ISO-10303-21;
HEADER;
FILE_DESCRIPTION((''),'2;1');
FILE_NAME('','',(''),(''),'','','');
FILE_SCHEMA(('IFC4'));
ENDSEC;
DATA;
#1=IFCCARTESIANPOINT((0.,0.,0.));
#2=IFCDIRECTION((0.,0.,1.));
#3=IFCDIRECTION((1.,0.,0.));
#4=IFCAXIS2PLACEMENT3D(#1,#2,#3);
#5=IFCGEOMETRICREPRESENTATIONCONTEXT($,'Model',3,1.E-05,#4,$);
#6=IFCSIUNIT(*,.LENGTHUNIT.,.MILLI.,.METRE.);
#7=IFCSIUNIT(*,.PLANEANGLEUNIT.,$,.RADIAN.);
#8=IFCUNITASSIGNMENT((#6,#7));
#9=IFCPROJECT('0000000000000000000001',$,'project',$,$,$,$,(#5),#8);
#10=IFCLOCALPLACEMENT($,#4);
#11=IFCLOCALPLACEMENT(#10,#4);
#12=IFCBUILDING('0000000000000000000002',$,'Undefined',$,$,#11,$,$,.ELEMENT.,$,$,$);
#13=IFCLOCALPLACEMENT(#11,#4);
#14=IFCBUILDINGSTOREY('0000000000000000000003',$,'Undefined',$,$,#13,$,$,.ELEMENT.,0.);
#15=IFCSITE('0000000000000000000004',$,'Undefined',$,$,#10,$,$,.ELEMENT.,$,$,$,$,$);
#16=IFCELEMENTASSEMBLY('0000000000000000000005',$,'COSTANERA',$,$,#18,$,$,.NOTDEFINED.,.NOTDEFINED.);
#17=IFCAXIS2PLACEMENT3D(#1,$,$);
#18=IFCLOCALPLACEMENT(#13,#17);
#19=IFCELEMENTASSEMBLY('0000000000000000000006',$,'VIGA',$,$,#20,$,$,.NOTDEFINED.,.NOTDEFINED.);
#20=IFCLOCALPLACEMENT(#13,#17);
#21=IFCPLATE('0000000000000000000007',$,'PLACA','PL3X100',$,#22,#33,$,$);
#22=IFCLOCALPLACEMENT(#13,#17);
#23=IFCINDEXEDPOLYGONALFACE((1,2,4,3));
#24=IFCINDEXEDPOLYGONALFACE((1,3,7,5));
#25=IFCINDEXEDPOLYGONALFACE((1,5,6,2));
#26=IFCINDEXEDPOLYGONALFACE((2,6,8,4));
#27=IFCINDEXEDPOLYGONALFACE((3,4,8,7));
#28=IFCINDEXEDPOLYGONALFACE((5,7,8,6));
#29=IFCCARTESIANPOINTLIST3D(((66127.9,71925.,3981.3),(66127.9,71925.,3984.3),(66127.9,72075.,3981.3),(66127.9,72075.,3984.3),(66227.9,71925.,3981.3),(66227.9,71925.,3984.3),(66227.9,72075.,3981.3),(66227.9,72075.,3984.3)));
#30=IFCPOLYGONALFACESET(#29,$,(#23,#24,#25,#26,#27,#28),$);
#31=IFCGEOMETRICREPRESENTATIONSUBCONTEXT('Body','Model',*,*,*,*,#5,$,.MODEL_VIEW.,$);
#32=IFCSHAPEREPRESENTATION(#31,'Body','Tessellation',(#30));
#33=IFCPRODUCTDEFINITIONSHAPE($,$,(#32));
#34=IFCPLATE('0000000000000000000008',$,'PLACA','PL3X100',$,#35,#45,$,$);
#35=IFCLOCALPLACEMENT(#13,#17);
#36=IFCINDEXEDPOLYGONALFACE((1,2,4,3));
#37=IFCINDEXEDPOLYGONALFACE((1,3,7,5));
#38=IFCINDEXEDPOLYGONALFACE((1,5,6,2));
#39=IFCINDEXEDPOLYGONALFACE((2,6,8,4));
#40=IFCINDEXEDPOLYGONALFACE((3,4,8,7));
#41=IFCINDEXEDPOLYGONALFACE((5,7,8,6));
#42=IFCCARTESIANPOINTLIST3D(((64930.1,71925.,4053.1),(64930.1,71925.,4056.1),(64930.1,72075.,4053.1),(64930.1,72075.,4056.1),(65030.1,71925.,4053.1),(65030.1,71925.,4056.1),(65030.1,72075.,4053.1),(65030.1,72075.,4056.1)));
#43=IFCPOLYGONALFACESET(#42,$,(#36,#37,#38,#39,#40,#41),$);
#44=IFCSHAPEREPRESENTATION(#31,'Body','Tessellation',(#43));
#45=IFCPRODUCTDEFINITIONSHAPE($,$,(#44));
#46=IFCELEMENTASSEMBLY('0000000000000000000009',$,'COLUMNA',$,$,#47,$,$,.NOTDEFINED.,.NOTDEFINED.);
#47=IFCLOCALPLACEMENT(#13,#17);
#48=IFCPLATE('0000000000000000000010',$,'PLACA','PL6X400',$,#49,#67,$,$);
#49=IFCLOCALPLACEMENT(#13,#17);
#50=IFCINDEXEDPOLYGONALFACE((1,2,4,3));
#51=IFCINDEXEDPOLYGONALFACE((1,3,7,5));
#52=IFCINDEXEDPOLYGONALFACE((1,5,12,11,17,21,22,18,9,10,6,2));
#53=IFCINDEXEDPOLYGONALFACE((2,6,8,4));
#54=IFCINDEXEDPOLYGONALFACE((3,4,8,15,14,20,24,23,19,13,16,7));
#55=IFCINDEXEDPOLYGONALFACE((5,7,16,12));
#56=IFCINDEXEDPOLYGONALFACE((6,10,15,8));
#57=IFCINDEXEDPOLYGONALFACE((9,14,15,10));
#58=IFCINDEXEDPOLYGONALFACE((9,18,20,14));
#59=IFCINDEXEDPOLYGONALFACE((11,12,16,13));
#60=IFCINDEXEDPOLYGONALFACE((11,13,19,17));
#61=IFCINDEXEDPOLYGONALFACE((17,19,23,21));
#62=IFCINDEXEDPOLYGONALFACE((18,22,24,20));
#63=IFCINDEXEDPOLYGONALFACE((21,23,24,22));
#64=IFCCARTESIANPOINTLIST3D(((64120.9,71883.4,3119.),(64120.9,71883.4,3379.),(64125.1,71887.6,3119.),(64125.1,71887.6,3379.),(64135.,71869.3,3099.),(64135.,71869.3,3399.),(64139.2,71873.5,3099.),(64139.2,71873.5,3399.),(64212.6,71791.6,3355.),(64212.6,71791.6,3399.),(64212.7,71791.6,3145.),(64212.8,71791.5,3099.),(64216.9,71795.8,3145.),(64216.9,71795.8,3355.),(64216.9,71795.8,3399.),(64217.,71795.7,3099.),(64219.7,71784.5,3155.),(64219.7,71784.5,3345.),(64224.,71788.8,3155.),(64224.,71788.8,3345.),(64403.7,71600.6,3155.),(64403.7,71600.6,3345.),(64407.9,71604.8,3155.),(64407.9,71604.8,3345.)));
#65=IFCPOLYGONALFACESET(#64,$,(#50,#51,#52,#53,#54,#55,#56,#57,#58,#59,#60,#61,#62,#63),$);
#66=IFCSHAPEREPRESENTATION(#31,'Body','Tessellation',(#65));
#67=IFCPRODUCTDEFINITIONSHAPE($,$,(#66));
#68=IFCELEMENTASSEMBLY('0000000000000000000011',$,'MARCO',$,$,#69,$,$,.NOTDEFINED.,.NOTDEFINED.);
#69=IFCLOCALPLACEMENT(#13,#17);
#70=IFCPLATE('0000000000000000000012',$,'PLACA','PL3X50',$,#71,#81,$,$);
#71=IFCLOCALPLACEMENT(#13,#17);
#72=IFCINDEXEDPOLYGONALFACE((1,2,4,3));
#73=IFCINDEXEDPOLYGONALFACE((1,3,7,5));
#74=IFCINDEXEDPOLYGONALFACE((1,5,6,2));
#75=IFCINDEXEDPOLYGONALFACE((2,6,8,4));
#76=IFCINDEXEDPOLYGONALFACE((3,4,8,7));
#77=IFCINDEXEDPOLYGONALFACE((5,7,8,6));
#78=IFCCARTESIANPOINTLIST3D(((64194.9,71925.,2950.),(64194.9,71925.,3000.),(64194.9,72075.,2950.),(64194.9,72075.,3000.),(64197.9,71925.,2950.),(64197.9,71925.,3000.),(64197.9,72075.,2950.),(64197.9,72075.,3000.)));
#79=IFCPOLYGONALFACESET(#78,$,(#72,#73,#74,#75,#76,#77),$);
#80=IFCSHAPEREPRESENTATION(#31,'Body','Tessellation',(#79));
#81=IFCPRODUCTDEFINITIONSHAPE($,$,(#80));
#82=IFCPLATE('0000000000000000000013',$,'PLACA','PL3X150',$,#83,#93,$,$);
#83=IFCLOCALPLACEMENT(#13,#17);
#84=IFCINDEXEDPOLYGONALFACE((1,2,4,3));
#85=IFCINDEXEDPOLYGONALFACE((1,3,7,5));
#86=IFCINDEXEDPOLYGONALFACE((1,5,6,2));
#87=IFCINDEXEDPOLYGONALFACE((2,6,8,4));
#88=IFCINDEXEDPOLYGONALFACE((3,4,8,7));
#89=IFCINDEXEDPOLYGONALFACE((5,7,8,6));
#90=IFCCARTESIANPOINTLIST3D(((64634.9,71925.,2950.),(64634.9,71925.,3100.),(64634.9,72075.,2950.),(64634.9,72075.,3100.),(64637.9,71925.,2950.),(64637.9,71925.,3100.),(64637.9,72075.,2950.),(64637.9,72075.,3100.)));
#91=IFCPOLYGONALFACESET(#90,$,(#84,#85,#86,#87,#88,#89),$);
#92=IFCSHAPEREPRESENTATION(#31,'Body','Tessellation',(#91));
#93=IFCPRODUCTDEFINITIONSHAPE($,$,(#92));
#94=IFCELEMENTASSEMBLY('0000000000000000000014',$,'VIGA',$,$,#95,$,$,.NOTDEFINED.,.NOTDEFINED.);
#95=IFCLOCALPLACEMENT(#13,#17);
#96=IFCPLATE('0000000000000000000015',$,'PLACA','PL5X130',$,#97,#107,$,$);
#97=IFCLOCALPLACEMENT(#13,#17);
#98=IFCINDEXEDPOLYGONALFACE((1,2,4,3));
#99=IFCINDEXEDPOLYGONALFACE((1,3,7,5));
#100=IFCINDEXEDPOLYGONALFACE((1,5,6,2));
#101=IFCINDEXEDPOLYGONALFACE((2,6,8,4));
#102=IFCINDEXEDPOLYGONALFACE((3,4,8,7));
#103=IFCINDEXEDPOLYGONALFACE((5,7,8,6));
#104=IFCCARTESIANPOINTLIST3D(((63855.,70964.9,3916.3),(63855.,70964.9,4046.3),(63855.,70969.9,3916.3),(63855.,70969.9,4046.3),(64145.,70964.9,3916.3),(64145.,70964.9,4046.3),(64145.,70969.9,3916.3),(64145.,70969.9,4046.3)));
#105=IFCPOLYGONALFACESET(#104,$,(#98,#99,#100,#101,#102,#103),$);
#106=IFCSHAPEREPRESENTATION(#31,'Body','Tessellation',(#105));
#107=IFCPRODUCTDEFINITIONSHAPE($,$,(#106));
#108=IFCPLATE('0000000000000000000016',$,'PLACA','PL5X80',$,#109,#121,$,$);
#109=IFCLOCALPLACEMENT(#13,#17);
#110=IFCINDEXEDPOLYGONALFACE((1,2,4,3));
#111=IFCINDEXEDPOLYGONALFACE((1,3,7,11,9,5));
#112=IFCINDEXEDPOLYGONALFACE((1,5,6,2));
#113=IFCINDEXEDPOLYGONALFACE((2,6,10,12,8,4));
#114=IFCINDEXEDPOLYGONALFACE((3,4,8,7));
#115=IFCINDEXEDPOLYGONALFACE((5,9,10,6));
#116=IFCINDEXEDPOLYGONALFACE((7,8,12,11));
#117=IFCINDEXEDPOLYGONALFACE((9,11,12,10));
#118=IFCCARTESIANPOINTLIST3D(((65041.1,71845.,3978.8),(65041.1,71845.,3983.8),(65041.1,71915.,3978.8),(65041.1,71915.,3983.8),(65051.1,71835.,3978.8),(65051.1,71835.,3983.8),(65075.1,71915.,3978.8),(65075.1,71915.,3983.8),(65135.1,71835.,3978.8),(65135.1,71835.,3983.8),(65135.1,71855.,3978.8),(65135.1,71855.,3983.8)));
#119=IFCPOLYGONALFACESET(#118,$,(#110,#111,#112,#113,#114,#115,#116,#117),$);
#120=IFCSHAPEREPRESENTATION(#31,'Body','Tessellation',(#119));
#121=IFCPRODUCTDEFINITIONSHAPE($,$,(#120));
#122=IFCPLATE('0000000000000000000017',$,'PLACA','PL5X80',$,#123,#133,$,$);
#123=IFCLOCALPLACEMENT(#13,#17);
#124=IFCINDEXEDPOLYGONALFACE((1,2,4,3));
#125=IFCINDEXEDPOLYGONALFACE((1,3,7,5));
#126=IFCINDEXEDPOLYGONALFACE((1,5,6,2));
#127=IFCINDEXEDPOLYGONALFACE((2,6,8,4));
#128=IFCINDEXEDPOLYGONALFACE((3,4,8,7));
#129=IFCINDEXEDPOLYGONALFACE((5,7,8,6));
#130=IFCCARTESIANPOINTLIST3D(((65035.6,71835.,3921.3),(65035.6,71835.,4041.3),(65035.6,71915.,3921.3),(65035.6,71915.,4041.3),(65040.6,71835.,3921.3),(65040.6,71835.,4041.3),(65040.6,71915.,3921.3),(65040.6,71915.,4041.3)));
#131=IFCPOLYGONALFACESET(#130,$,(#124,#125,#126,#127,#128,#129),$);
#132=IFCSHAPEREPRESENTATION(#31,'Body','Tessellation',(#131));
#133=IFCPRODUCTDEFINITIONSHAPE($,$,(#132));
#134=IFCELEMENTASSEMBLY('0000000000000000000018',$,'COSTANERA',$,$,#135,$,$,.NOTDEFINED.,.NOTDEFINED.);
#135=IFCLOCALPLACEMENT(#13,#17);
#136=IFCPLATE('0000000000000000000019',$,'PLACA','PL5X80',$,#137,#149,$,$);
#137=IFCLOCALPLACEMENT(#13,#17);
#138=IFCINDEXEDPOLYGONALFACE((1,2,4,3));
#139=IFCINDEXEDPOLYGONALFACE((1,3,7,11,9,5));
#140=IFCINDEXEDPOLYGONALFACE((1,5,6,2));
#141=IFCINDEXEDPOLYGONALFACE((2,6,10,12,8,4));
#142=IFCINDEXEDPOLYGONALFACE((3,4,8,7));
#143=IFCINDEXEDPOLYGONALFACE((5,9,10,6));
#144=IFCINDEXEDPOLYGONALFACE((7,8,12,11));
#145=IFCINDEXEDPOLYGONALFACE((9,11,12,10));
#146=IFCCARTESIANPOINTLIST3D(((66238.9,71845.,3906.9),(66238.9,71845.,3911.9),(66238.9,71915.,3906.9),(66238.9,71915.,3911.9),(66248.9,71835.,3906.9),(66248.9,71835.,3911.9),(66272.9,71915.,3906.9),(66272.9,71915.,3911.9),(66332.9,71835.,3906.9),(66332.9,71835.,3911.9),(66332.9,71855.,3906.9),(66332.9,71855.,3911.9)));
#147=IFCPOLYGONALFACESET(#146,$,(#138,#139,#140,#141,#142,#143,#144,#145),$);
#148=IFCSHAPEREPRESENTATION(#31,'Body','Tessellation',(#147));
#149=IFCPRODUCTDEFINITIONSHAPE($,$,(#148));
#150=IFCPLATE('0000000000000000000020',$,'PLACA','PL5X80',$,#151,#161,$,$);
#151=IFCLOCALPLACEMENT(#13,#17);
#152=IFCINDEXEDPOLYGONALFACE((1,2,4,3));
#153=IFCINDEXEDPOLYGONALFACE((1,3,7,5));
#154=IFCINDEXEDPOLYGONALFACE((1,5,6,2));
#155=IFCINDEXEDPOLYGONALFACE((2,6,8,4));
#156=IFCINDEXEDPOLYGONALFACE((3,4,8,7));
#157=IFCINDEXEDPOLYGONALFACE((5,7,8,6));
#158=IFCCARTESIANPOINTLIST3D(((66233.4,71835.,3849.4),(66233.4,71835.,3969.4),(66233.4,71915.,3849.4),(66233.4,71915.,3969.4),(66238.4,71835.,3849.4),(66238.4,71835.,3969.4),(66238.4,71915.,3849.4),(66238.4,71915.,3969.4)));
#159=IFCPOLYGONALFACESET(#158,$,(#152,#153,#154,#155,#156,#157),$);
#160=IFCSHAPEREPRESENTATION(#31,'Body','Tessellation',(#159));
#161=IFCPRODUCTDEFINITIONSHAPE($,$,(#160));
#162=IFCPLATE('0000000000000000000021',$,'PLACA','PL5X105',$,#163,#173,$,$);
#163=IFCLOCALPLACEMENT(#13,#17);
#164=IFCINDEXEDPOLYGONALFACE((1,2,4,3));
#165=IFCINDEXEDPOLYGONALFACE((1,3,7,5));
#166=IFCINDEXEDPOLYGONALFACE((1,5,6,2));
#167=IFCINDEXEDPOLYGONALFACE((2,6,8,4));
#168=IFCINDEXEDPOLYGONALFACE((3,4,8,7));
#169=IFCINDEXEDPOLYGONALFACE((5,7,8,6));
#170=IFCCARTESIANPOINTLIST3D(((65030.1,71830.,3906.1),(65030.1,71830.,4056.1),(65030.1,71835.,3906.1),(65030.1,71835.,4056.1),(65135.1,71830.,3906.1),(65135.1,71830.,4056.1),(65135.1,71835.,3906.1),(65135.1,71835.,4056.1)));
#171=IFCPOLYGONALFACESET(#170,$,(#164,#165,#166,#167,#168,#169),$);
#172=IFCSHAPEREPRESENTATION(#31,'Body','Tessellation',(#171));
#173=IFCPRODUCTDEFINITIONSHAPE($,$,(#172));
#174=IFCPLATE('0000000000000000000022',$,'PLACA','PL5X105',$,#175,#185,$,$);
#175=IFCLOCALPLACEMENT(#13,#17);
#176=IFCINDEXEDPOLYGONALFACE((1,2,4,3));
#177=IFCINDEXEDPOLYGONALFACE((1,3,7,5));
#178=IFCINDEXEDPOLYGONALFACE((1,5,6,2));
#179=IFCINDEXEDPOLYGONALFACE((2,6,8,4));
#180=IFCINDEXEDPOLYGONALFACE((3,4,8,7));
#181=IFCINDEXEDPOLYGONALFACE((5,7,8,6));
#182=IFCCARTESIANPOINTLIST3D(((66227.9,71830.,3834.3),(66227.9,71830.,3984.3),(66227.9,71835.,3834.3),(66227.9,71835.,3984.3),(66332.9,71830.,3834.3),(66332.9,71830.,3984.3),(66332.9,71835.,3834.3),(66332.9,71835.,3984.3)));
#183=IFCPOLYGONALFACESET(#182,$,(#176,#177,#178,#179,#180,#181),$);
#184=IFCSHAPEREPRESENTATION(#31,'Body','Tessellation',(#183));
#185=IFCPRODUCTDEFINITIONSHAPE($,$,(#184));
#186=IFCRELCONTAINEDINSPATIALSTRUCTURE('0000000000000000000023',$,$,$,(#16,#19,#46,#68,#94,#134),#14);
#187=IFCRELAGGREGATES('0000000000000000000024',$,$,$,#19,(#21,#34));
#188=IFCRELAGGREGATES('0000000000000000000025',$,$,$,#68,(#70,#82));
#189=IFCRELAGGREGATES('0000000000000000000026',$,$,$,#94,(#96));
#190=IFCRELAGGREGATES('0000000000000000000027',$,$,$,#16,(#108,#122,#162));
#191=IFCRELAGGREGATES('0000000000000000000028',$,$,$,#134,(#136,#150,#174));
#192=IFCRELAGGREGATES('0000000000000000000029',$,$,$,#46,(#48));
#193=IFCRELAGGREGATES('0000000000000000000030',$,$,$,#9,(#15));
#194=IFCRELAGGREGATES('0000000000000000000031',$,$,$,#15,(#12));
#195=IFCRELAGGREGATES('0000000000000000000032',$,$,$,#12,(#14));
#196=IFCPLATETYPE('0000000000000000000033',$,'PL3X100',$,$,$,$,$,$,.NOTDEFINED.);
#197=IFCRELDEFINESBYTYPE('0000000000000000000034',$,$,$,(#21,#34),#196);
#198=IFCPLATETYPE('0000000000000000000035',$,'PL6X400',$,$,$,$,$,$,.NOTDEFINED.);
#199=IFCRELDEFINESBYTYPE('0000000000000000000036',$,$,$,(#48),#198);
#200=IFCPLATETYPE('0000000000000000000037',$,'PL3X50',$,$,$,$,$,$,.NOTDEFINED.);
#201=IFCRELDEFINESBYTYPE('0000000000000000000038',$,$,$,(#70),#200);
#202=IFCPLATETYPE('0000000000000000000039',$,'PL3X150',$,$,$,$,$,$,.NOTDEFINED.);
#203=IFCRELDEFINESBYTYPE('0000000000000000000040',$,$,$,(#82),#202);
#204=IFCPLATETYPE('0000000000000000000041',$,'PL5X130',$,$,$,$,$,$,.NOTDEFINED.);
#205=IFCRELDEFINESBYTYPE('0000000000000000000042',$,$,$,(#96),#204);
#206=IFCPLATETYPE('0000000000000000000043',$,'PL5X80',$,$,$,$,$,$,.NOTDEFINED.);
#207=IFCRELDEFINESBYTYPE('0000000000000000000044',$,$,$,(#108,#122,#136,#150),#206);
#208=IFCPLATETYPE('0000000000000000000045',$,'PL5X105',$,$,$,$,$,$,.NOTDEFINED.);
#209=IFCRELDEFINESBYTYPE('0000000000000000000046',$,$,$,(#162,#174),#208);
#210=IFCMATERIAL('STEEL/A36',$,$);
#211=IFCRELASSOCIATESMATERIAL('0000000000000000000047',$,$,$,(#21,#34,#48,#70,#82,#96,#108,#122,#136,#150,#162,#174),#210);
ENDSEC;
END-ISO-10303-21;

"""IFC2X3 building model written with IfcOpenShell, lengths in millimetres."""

from ifc_helpers import new_model, si_unit, frame, origin_with_axes, place, context, subcontext, project, spatial, polyline, outline, extrude, material, type_object, element, aggregate, save


model = new_model("IFC2X3")

# Units and contexts
model_context = context("Model", 3, precision=1e-05, world=origin_with_axes())
body_context = subcontext(model_context, "Body", "Model", "MODEL_VIEW")
ifc_project = project(units=[si_unit("LENGTHUNIT", "METRE", prefix="MILLI"), si_unit("PLANEANGLEUNIT", "RADIAN")], contexts=[model_context])

# Site, building, storey
site_placement = place(None, origin_with_axes())
site = spatial("IfcSite", under=ifc_project, at=site_placement, Name="Undefined", CompositionType="ELEMENT")
building_placement = place(site_placement, origin_with_axes())
building = spatial("IfcBuilding", under=site, at=building_placement, Name="Undefined", CompositionType="ELEMENT")
storey_placement = place(building_placement, origin_with_axes())
storey = spatial("IfcBuildingStorey", under=building, at=storey_placement, Name="Undefined", CompositionType="ELEMENT", Elevation=0.0)

# Shared definitions
ifc_material_1 = material(Name="STEEL/A36")

# Element assembly
assembly_1_placement = place(storey_placement, origin_with_axes())
assembly_1 = element("IfcElementAssembly", 1, at=assembly_1_placement, inside=storey, Name="COSTANERA", AssemblyPlace="NOTDEFINED", PredefinedType="NOTDEFINED")

# Element assembly, plates
assembly_2_placement = place(storey_placement, origin_with_axes())
assembly_2 = element("IfcElementAssembly", 2, at=assembly_2_placement, inside=storey, Name="VIGA", AssemblyPlace="NOTDEFINED", PredefinedType="NOTDEFINED")
plate_type_1 = type_object("IfcPlateType", Name="PL3X100", PredefinedType="NOTDEFINED")
plate_1_placement = place(assembly_2_placement, frame((66227.9, 71925.0, 3982.8), z_axis=(0.0, 0.0, -1.0), x_axis=(-1.0, 0.0, 0.0)))
plate_1 = element("IfcPlate", 3, at=plate_1_placement, type_object=plate_type_1, material=ifc_material_1, Name="PLACA", Description="PL3X100", context=body_context, shape_type="SweptSolid", body=[
    extrude(outline(polyline([(0.0, 0.0), (100.0, 0.0), (100.0, 150.0), (0.0, 150.0), (0.0, 0.0)])), frame((0.0, 0.0, -1.5), z_axis=(0.0, 0.0, 1.0), x_axis=(1.0, 0.0, 0.0)), (0.0, 0.0, 1.0), 3.0),
])
plate_2_placement = place(assembly_2_placement, frame((65030.1, 71925.0, 4054.6), z_axis=(0.0, 0.0, -1.0), x_axis=(-1.0, 0.0, 0.0)))
plate_2 = element("IfcPlate", 4, at=plate_2_placement, type_object=plate_type_1, material=ifc_material_1, Name="PLACA", Description="PL3X100", context=body_context, shape_type="SweptSolid", body=[
    extrude(outline(polyline([(0.0, 0.0), (100.0, 0.0), (100.0, 150.0), (0.0, 150.0), (0.0, 0.0)])), frame((0.0, 0.0, -1.5), z_axis=(0.0, 0.0, 1.0), x_axis=(1.0, 0.0, 0.0)), (0.0, 0.0, 1.0), 3.0),
])
aggregate(assembly_2, [plate_1, plate_2])

# Element assembly, plate
assembly_3_placement = place(storey_placement, origin_with_axes())
assembly_3 = element("IfcElementAssembly", 5, at=assembly_3_placement, inside=storey, Name="COLUMNA", AssemblyPlace="NOTDEFINED", PredefinedType="NOTDEFINED")
plate_type_2 = type_object("IfcPlateType", Name="PL6X400", PredefinedType="NOTDEFINED")
plate_3_placement = place(assembly_3_placement, frame((64123.0, 71885.5, 3099.0), z_axis=(-0.707111, -0.707103, 0.0), x_axis=(0.707103, -0.707111, 0.0)))
plate_3 = element("IfcPlate", 6, at=plate_3_placement, type_object=plate_type_2, material=ifc_material_1, Name="PLACA", Description="PL6X400", context=body_context, shape_type="SweptSolid", body=[
    extrude(outline(polyline([(0.0, 20.0), (20.0, 0.0), (130.0, 0.0), (129.8, 46.0), (139.8, 56.0), (400.0, 56.0), (400.0, 246.0), (139.8, 246.0), (129.8, 256.0), (129.8, 300.0), (20.0, 300.0), (0.0, 280.0), (0.0, 20.0)])), frame((0.0, 0.0, -3.0), z_axis=(0.0, 0.0, 1.0), x_axis=(1.0, 0.0, 0.0)), (0.0, 0.0, 1.0), 6.0),
])

# Element assembly, plates
assembly_4_placement = place(storey_placement, origin_with_axes())
assembly_4 = element("IfcElementAssembly", 7, at=assembly_4_placement, inside=storey, Name="MARCO", AssemblyPlace="NOTDEFINED", PredefinedType="NOTDEFINED")
plate_type_3 = type_object("IfcPlateType", Name="PL3X50", PredefinedType="NOTDEFINED")
plate_4_placement = place(assembly_4_placement, frame((64196.4, 71925.0, 3000.0), z_axis=(1.0, 0.0, 0.0), x_axis=(0.0, 0.0, -1.0)))
plate_4 = element("IfcPlate", 8, at=plate_4_placement, type_object=plate_type_3, material=ifc_material_1, Name="PLACA", Description="PL3X50", context=body_context, shape_type="SweptSolid", body=[
    extrude(outline(polyline([(0.0, 0.0), (50.0, 0.0), (50.0, 150.0), (0.0, 150.0), (0.0, 0.0)])), frame((0.0, 0.0, -1.5), z_axis=(0.0, 0.0, 1.0), x_axis=(1.0, 0.0, 0.0)), (0.0, 0.0, 1.0), 3.0),
])
plate_type_4 = type_object("IfcPlateType", Name="PL3X150", PredefinedType="NOTDEFINED")
plate_5_placement = place(assembly_4_placement, frame((64636.4, 71925.0, 2950.0), z_axis=(1.0, 0.0, 0.0), x_axis=(0.0, 1.0, 0.0)))
plate_5 = element("IfcPlate", 9, at=plate_5_placement, type_object=plate_type_4, material=ifc_material_1, Name="PLACA", Description="PL3X150", context=body_context, shape_type="SweptSolid", body=[
    extrude(outline(polyline([(0.0, 0.0), (150.0, 0.0), (150.0, 150.0), (0.0, 150.0), (0.0, 0.0)])), frame((0.0, 0.0, -1.5), z_axis=(0.0, 0.0, 1.0), x_axis=(1.0, 0.0, 0.0)), (0.0, 0.0, 1.0), 3.0),
])
aggregate(assembly_4, [plate_4, plate_5])

# Element assembly, plate
assembly_5_placement = place(storey_placement, origin_with_axes())
assembly_5 = element("IfcElementAssembly", 10, at=assembly_5_placement, inside=storey, Name="VIGA", AssemblyPlace="NOTDEFINED", PredefinedType="NOTDEFINED")
plate_type_5 = type_object("IfcPlateType", Name="PL5X130", PredefinedType="NOTDEFINED")
plate_6_placement = place(assembly_5_placement, frame((64145.0, 70967.4, 4046.3), z_axis=(0.0, -1.0, 0.0), x_axis=(-1.0, 0.0, 0.0)))
plate_6 = element("IfcPlate", 11, at=plate_6_placement, type_object=plate_type_5, material=ifc_material_1, Name="PLACA", Description="PL5X130", context=body_context, shape_type="SweptSolid", body=[
    extrude(outline(polyline([(0.0, 0.0), (290.0, 0.0), (290.0, 130.0), (0.0, 130.0), (0.0, 0.0)])), frame((0.0, 0.0, -2.5), z_axis=(0.0, 0.0, 1.0), x_axis=(1.0, 0.0, 0.0)), (0.0, 0.0, 1.0), 5.0),
])
aggregate(assembly_5, [plate_6])

# Plates
plate_type_6 = type_object("IfcPlateType", Name="PL5X80", PredefinedType="NOTDEFINED")
plate_7_placement = place(assembly_1_placement, frame((65041.1, 71915.0, 3981.3), z_axis=(0.0, 0.0, 1.0), x_axis=(0.0, -1.0, 0.0)))
plate_7 = element("IfcPlate", 12, at=plate_7_placement, type_object=plate_type_6, material=ifc_material_1, Name="PLACA", Description="PL5X80", context=body_context, shape_type="SweptSolid", body=[
    extrude(outline(polyline([(0.0, 0.0), (70.0, 0.0), (80.0, 10.0), (80.0, 94.0), (60.0, 94.0), (0.0, 34.0), (0.0, 0.0)])), frame((0.0, 0.0, -2.5), z_axis=(0.0, 0.0, 1.0), x_axis=(1.0, 0.0, 0.0)), (0.0, 0.0, 1.0), 5.0),
])
plate_8_placement = place(assembly_1_placement, frame((65038.1, 71915.0, 4041.3), z_axis=(1.0, 0.0, 0.0), x_axis=(0.0, -1.0, 0.0)))
plate_8 = element("IfcPlate", 13, at=plate_8_placement, type_object=plate_type_6, material=ifc_material_1, Name="PLACA", Description="PL5X80", context=body_context, shape_type="SweptSolid", body=[
    extrude(outline(polyline([(0.0, 0.0), (80.0, 0.0), (80.0, 120.0), (0.0, 120.0), (0.0, 0.0)])), frame((0.0, 0.0, -2.5), z_axis=(0.0, 0.0, 1.0), x_axis=(1.0, 0.0, 0.0)), (0.0, 0.0, 1.0), 5.0),
])

# Element assembly, plates
assembly_6_placement = place(storey_placement, origin_with_axes())
assembly_6 = element("IfcElementAssembly", 14, at=assembly_6_placement, inside=storey, Name="COSTANERA", AssemblyPlace="NOTDEFINED", PredefinedType="NOTDEFINED")
plate_9_placement = place(assembly_6_placement, frame((66238.9, 71915.0, 3909.4), z_axis=(0.0, 0.0, 1.0), x_axis=(0.0, -1.0, 0.0)))
plate_9 = element("IfcPlate", 15, at=plate_9_placement, type_object=plate_type_6, material=ifc_material_1, Name="PLACA", Description="PL5X80", context=body_context, shape_type="SweptSolid", body=[
    extrude(outline(polyline([(0.0, 0.0), (70.0, 0.0), (80.0, 10.0), (80.0, 94.0), (60.0, 94.0), (0.0, 34.0), (0.0, 0.0)])), frame((0.0, 0.0, -2.5), z_axis=(0.0, 0.0, 1.0), x_axis=(1.0, 0.0, 0.0)), (0.0, 0.0, 1.0), 5.0),
])
plate_10_placement = place(assembly_6_placement, frame((66235.9, 71915.0, 3969.4), z_axis=(1.0, 0.0, 0.0), x_axis=(0.0, -1.0, 0.0)))
plate_10 = element("IfcPlate", 16, at=plate_10_placement, type_object=plate_type_6, material=ifc_material_1, Name="PLACA", Description="PL5X80", context=body_context, shape_type="SweptSolid", body=[
    extrude(outline(polyline([(0.0, 0.0), (80.0, 0.0), (80.0, 120.0), (0.0, 120.0), (0.0, 0.0)])), frame((0.0, 0.0, -2.5), z_axis=(0.0, 0.0, 1.0), x_axis=(1.0, 0.0, 0.0)), (0.0, 0.0, 1.0), 5.0),
])

# Plates
plate_type_7 = type_object("IfcPlateType", Name="PL5X105", PredefinedType="NOTDEFINED")
plate_11_placement = place(assembly_1_placement, frame((65030.1, 71832.5, 3906.1), z_axis=(0.0, -1.0, 0.0), x_axis=(1.0, 0.0, 0.0)))
plate_11 = element("IfcPlate", 17, at=plate_11_placement, type_object=plate_type_7, material=ifc_material_1, Name="PLACA", Description="PL5X105", context=body_context, shape_type="SweptSolid", body=[
    extrude(outline(polyline([(0.0, 0.0), (105.0, 0.0), (105.0, 150.0), (0.0, 150.0), (0.0, 0.0)])), frame((0.0, 0.0, -2.5), z_axis=(0.0, 0.0, 1.0), x_axis=(1.0, 0.0, 0.0)), (0.0, 0.0, 1.0), 5.0),
])
plate_12_placement = place(assembly_6_placement, frame((66227.9, 71832.5, 3834.3), z_axis=(0.0, -1.0, 0.0), x_axis=(1.0, 0.0, 0.0)))
plate_12 = element("IfcPlate", 18, at=plate_12_placement, type_object=plate_type_7, material=ifc_material_1, Name="PLACA", Description="PL5X105", context=body_context, shape_type="SweptSolid", body=[
    extrude(outline(polyline([(0.0, 0.0), (105.0, 0.0), (105.0, 150.0), (0.0, 150.0), (0.0, 0.0)])), frame((0.0, 0.0, -2.5), z_axis=(0.0, 0.0, 1.0), x_axis=(1.0, 0.0, 0.0)), (0.0, 0.0, 1.0), 5.0),
])

aggregate(assembly_1, [plate_7, plate_8, plate_11])
aggregate(assembly_6, [plate_9, plate_10, plate_12])
aggregate(assembly_3, [plate_3])

save(model, "model.ifc")
